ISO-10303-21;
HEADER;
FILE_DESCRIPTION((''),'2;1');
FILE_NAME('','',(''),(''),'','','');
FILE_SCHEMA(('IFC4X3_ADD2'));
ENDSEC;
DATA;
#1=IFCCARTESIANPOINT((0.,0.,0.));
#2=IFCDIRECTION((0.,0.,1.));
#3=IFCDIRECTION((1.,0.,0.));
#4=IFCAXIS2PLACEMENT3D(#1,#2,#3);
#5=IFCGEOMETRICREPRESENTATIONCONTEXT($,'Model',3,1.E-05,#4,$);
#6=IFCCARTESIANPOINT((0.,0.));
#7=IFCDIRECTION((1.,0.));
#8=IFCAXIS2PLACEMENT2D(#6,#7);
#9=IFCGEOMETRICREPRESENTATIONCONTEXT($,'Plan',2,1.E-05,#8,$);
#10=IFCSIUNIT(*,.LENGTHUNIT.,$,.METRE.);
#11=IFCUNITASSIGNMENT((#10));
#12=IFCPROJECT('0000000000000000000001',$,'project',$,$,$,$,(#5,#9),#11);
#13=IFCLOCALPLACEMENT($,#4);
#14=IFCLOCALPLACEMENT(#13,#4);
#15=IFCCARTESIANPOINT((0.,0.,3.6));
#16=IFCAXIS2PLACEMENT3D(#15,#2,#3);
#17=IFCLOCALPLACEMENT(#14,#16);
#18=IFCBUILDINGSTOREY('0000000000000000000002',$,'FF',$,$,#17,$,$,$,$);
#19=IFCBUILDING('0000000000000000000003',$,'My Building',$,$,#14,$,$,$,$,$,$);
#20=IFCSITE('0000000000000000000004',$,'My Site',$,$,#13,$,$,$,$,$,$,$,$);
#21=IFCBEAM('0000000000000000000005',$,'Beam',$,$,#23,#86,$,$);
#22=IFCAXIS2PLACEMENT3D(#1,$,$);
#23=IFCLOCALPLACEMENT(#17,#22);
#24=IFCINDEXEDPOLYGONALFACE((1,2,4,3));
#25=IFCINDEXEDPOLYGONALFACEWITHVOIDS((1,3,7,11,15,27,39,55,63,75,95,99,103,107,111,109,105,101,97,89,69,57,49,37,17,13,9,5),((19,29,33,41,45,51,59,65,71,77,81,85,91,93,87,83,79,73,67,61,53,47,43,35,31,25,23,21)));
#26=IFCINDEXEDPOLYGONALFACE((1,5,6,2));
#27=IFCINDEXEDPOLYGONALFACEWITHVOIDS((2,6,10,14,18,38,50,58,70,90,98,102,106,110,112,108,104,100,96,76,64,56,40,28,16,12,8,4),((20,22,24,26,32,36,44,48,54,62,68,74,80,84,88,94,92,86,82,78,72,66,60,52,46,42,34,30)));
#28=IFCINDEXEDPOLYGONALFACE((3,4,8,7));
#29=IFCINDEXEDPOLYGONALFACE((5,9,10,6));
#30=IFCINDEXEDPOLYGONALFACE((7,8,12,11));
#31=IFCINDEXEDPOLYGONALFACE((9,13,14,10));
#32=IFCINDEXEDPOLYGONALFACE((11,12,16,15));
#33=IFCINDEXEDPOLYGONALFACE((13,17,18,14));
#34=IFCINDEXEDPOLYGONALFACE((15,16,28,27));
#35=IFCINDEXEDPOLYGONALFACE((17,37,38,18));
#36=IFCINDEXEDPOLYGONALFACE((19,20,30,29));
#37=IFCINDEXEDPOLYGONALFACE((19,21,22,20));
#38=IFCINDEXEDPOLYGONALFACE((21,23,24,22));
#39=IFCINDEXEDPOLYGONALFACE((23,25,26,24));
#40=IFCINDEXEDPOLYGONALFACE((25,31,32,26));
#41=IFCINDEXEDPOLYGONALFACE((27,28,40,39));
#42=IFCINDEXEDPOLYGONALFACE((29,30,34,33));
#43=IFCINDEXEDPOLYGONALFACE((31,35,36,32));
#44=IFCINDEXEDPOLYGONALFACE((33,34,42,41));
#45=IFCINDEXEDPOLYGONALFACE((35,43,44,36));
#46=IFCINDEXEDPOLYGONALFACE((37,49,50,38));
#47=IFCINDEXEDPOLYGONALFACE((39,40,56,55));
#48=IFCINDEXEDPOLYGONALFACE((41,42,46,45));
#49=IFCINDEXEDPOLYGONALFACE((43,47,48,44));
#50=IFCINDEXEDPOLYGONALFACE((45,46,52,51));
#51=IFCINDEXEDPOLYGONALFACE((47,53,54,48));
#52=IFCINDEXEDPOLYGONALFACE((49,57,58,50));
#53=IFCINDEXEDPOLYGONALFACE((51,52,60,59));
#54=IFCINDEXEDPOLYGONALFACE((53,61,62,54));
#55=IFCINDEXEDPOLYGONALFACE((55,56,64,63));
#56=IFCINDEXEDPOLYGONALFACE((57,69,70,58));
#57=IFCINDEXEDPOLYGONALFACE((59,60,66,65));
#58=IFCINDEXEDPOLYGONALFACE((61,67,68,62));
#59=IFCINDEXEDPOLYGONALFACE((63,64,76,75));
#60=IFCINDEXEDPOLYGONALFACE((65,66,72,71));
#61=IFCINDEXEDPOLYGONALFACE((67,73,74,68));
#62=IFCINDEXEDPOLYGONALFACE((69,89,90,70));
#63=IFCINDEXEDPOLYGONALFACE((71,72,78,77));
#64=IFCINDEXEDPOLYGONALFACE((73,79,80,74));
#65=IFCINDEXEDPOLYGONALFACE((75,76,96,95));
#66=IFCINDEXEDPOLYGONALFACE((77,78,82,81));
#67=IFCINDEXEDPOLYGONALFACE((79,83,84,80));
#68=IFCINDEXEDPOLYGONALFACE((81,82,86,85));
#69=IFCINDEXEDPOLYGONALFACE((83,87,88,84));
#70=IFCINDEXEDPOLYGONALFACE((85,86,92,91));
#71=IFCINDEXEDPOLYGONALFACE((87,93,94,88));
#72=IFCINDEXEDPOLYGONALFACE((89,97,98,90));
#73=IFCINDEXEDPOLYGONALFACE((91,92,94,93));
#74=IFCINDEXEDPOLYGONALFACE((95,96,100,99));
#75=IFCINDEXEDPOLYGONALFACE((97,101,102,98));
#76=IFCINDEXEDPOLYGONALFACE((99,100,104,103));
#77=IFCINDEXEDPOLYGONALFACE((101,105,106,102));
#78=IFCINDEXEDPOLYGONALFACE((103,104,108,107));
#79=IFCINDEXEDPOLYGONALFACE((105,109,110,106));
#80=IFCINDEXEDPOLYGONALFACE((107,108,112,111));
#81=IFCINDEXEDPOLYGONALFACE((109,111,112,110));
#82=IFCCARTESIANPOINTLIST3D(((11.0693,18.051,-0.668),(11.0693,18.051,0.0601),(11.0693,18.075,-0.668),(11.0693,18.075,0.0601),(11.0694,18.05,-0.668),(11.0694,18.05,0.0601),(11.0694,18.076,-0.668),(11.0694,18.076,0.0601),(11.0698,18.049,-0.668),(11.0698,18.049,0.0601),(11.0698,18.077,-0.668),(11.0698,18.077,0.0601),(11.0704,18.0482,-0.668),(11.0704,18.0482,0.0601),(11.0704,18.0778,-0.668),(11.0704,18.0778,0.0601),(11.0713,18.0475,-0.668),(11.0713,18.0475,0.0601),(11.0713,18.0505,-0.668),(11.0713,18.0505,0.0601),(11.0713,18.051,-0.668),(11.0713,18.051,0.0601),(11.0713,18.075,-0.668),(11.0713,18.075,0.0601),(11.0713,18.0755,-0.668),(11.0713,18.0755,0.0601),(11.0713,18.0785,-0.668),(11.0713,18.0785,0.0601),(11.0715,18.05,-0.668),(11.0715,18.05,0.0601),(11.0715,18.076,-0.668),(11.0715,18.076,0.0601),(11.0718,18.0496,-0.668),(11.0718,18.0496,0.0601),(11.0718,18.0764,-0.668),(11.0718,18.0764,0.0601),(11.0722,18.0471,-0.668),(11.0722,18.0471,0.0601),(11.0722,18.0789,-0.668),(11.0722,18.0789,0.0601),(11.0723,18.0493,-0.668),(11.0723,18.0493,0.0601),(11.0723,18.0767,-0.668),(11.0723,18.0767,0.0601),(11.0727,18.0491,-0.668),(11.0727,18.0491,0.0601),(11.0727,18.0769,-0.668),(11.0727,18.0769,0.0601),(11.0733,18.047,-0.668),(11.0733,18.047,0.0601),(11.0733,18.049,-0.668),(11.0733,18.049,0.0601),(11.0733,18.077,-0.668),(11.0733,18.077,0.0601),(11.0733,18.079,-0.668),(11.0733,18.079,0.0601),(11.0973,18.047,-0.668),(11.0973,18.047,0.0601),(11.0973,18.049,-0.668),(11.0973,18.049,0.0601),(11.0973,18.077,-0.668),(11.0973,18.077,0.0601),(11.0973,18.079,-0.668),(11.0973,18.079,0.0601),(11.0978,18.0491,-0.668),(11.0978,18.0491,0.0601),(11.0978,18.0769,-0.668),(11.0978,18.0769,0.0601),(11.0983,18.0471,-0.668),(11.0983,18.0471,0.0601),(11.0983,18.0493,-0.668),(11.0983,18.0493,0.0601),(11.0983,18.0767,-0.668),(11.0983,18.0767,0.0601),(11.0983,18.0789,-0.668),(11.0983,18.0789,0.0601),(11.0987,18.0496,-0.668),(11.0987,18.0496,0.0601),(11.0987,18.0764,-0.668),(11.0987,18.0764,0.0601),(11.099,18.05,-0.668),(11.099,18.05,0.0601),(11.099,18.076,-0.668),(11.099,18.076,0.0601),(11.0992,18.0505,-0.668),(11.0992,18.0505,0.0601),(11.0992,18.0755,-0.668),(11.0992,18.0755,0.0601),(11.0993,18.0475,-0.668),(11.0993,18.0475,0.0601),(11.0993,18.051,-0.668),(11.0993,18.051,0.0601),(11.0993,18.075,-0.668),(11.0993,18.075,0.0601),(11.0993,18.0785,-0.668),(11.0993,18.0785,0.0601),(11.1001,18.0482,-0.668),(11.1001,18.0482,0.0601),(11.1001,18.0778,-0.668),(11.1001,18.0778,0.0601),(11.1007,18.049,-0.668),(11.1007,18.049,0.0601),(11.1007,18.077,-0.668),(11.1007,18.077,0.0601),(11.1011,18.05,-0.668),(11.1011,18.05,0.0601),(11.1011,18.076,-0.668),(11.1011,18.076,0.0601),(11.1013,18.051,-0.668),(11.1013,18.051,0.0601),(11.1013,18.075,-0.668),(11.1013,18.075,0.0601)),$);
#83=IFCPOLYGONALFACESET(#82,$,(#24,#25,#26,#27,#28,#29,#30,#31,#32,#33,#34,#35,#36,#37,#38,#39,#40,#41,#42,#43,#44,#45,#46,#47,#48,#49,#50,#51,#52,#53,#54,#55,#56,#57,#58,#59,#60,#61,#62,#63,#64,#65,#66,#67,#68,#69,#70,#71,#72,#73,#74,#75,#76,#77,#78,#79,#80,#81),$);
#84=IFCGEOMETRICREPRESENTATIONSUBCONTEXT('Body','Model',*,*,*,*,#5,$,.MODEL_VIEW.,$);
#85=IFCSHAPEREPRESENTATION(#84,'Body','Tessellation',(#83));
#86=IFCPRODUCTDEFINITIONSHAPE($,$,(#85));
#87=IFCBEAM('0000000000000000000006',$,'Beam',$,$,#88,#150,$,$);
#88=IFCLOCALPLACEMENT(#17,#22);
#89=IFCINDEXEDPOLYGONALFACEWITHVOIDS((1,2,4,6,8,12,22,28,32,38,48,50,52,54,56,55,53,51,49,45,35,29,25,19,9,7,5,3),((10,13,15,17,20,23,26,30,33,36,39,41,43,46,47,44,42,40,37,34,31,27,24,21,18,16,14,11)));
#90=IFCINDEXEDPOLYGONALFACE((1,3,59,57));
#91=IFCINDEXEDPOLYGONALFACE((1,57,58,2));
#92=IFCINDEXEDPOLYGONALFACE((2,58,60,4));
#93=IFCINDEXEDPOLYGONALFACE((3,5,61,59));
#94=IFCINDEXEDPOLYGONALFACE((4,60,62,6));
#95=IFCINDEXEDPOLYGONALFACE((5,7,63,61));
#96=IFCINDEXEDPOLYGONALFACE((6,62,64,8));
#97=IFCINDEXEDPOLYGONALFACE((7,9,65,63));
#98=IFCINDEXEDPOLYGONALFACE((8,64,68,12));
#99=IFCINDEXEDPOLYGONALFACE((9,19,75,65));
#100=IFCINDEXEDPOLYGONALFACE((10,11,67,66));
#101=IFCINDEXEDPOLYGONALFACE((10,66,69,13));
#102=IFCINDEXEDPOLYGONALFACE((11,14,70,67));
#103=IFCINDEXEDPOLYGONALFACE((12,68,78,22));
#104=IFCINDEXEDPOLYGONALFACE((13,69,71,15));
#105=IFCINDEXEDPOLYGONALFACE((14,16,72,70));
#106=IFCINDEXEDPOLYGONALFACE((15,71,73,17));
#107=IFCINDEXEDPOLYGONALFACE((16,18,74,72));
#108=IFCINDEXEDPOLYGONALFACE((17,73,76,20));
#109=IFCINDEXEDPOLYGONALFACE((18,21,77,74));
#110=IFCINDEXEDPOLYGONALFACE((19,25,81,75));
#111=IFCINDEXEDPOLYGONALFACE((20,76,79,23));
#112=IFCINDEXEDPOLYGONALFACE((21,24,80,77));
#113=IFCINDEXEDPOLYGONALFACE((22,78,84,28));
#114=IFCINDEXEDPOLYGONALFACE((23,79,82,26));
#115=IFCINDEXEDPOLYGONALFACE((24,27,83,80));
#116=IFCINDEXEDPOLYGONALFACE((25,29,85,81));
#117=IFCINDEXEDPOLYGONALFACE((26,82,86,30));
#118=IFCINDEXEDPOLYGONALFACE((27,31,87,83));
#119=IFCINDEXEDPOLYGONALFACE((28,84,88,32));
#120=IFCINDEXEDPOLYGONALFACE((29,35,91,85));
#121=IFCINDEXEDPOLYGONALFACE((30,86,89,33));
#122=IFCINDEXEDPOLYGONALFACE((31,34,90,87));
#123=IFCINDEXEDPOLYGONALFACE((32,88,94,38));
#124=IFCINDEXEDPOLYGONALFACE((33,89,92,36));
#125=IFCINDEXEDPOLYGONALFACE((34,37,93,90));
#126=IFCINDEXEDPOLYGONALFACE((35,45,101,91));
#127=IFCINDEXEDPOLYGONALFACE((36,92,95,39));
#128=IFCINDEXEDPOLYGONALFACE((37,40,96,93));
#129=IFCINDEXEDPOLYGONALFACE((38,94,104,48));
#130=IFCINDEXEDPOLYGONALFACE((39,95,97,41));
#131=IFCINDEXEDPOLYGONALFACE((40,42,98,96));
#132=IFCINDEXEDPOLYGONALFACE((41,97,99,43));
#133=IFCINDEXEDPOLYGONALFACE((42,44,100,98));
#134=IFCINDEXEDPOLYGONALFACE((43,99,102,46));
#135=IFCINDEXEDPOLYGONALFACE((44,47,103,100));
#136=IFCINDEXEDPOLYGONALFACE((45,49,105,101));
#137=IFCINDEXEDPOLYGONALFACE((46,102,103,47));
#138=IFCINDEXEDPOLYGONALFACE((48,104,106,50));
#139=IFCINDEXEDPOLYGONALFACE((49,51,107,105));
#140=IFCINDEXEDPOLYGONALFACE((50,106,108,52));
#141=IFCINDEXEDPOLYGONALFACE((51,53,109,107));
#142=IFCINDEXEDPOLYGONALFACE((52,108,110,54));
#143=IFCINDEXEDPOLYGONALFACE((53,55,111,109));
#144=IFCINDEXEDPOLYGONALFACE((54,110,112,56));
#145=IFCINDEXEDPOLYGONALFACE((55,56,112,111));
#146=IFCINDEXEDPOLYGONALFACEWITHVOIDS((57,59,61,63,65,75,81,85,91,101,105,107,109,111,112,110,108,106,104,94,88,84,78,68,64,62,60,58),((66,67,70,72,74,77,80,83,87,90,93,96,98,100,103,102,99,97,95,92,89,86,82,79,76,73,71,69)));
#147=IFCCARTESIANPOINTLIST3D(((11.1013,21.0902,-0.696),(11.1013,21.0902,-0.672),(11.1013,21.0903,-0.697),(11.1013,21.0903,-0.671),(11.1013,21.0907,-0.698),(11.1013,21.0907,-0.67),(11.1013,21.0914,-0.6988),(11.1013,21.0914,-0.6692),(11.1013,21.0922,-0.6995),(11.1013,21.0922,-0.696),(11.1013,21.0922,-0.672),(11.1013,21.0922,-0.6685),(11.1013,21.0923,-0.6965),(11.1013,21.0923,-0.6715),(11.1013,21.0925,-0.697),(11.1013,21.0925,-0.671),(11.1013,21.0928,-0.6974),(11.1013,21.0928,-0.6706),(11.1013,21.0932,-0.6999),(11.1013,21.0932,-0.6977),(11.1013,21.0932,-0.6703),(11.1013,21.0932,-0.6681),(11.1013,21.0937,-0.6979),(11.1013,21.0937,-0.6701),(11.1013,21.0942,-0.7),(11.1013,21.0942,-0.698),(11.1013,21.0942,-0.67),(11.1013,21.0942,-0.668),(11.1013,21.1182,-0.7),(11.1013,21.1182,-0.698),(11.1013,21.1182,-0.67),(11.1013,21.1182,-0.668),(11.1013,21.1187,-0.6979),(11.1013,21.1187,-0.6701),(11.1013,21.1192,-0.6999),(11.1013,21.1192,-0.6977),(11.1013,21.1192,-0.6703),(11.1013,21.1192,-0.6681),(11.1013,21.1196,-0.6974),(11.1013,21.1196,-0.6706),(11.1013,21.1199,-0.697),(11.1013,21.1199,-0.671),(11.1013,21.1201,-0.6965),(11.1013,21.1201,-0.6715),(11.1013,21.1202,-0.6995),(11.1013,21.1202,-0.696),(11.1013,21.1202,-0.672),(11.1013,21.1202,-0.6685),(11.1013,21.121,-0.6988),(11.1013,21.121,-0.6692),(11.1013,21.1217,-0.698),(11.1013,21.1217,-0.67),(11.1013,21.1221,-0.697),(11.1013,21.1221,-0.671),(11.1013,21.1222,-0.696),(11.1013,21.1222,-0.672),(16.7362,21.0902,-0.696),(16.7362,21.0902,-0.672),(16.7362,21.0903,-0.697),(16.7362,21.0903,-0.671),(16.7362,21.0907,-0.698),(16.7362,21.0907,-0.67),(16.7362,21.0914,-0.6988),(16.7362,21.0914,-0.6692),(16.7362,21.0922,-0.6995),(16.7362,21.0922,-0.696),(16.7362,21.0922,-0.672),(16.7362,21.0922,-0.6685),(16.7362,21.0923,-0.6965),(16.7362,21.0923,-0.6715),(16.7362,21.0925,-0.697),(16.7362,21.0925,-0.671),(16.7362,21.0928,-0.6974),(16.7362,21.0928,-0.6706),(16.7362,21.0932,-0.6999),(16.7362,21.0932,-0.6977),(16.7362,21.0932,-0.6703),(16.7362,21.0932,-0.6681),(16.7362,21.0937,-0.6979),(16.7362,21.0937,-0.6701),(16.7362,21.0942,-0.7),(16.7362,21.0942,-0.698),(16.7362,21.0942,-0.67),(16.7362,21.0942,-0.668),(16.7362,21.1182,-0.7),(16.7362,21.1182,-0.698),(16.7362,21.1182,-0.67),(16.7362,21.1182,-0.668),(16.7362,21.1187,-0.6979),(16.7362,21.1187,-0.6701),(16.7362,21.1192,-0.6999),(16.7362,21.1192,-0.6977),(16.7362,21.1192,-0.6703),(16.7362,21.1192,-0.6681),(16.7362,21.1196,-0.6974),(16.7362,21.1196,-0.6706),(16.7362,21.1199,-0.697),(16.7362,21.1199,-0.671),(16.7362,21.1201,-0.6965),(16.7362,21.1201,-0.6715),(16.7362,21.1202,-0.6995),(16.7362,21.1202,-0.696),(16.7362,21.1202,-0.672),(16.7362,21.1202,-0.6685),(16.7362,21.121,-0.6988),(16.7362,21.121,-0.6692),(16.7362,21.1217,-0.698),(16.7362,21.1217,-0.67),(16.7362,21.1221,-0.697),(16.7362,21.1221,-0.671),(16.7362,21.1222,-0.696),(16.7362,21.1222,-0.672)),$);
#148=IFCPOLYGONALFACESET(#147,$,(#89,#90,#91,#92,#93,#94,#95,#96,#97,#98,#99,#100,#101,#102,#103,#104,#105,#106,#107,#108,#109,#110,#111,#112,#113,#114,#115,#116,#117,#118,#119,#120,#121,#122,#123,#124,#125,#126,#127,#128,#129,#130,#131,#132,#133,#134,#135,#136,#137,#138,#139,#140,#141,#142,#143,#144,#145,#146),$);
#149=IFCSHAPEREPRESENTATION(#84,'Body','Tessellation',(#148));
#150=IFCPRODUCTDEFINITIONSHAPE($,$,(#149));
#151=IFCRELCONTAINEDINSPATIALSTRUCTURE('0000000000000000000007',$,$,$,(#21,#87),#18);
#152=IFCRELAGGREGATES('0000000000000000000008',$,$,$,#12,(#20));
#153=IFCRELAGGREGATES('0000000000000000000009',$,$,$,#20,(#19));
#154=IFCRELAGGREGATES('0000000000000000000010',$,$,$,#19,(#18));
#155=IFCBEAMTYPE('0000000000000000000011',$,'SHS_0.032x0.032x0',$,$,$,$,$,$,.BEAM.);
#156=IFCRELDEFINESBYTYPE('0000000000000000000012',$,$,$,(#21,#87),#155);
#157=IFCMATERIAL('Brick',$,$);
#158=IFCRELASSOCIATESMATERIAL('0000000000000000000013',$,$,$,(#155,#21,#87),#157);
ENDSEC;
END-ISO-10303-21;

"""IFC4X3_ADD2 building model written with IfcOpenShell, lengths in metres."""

from ifc_helpers import new_model, si_unit, frame, origin_with_axes, origin_2d_with_axis, place, context, subcontext, project, spatial, hollow_rectangle, extrude, material, material_profile, profile_set, profile_usage, type_object, element, save


model = new_model("IFC4X3_ADD2")

# Units and contexts
model_context = context("Model", 3, precision=1e-05, world=origin_with_axes())
plan_context = context("Plan", 2, precision=1e-05, world=origin_2d_with_axis())
body_context_1 = subcontext(model_context, "Body", "Model", "MODEL_VIEW")
ifc_project = project(units=[si_unit("LENGTHUNIT", "METRE")], contexts=[model_context, plan_context])

# Site, building, storey
site_placement = place(None, origin_with_axes())
site = spatial("IfcSite", under=ifc_project, at=site_placement, Name="My Site")
building_placement = place(site_placement, origin_with_axes())
building = spatial("IfcBuilding", under=site, at=building_placement, Name="My Building")
storey_placement = place(building_placement, frame((0.0, 0.0, 3.6), z_axis=(0.0, 0.0, 1.0), x_axis=(1.0, 0.0, 0.0)))
storey = spatial("IfcBuildingStorey", under=building, at=storey_placement, Name="FF")

# Beams
ifc_material_1 = material(Name="Brick")
ifc_material_profile_1 = material_profile(ifc_material_1, hollow_rectangle(XDim=0.032, YDim=0.032, WallThickness=0.002, InnerFilletRadius=0.002, OuterFilletRadius=0.004))
ifc_profile_set_1 = profile_set([ifc_material_profile_1])
beam_type_1 = type_object("IfcBeamType", Name="SHS_0.032x0.032x0", PredefinedType="BEAM", material=ifc_profile_set_1)
ifc_material_profile_2 = material_profile(ifc_material_1, hollow_rectangle(XDim=0.032, YDim=0.032, WallThickness=0.002, InnerFilletRadius=0.002, OuterFilletRadius=0.004))
ifc_profile_set_2 = profile_set([ifc_material_profile_2])
ifc_material_profile_3 = material_profile(ifc_material_1, hollow_rectangle(XDim=0.032, YDim=0.032, WallThickness=0.002, InnerFilletRadius=0.002, OuterFilletRadius=0.004))
ifc_profile_set_3 = profile_set([ifc_material_profile_3])
ifc_profile_usage_1 = profile_usage(ifc_profile_set_3, cardinal=5)
beam_1_placement = place(storey_placement, frame((11.0853, 18.063, -0.668), z_axis=(0.0, 0.0, 1.0), x_axis=(1.0, 0.0, 0.0)))
element("IfcBeam", 1, at=beam_1_placement, inside=storey, type_object=beam_type_1, material=ifc_profile_usage_1, Name="Beam", context=body_context_1, shape_type="SweptSolid", body=[
    extrude(hollow_rectangle(XDim=0.032, YDim=0.032, WallThickness=0.002, InnerFilletRadius=0.002, OuterFilletRadius=0.004), origin_with_axes(), (0.0, 0.0, 1.0), 0.7281),
])
ifc_profile_usage_2 = profile_usage(ifc_profile_set_2, cardinal=5)
beam_2_placement = place(storey_placement, frame((11.1013, 21.1062, -0.684), z_axis=(1.0, 0.0, 0.0), x_axis=(0.0, 1.0, 0.0)))
element("IfcBeam", 2, at=beam_2_placement, inside=storey, type_object=beam_type_1, material=ifc_profile_usage_2, Name="Beam", context=body_context_1, shape_type="SweptSolid", body=[
    extrude(hollow_rectangle(XDim=0.032, YDim=0.032, WallThickness=0.002, InnerFilletRadius=0.002, OuterFilletRadius=0.004), origin_with_axes(), (0.0, 0.0, 1.0), 5.635),
])

save(model, "model.ifc")
